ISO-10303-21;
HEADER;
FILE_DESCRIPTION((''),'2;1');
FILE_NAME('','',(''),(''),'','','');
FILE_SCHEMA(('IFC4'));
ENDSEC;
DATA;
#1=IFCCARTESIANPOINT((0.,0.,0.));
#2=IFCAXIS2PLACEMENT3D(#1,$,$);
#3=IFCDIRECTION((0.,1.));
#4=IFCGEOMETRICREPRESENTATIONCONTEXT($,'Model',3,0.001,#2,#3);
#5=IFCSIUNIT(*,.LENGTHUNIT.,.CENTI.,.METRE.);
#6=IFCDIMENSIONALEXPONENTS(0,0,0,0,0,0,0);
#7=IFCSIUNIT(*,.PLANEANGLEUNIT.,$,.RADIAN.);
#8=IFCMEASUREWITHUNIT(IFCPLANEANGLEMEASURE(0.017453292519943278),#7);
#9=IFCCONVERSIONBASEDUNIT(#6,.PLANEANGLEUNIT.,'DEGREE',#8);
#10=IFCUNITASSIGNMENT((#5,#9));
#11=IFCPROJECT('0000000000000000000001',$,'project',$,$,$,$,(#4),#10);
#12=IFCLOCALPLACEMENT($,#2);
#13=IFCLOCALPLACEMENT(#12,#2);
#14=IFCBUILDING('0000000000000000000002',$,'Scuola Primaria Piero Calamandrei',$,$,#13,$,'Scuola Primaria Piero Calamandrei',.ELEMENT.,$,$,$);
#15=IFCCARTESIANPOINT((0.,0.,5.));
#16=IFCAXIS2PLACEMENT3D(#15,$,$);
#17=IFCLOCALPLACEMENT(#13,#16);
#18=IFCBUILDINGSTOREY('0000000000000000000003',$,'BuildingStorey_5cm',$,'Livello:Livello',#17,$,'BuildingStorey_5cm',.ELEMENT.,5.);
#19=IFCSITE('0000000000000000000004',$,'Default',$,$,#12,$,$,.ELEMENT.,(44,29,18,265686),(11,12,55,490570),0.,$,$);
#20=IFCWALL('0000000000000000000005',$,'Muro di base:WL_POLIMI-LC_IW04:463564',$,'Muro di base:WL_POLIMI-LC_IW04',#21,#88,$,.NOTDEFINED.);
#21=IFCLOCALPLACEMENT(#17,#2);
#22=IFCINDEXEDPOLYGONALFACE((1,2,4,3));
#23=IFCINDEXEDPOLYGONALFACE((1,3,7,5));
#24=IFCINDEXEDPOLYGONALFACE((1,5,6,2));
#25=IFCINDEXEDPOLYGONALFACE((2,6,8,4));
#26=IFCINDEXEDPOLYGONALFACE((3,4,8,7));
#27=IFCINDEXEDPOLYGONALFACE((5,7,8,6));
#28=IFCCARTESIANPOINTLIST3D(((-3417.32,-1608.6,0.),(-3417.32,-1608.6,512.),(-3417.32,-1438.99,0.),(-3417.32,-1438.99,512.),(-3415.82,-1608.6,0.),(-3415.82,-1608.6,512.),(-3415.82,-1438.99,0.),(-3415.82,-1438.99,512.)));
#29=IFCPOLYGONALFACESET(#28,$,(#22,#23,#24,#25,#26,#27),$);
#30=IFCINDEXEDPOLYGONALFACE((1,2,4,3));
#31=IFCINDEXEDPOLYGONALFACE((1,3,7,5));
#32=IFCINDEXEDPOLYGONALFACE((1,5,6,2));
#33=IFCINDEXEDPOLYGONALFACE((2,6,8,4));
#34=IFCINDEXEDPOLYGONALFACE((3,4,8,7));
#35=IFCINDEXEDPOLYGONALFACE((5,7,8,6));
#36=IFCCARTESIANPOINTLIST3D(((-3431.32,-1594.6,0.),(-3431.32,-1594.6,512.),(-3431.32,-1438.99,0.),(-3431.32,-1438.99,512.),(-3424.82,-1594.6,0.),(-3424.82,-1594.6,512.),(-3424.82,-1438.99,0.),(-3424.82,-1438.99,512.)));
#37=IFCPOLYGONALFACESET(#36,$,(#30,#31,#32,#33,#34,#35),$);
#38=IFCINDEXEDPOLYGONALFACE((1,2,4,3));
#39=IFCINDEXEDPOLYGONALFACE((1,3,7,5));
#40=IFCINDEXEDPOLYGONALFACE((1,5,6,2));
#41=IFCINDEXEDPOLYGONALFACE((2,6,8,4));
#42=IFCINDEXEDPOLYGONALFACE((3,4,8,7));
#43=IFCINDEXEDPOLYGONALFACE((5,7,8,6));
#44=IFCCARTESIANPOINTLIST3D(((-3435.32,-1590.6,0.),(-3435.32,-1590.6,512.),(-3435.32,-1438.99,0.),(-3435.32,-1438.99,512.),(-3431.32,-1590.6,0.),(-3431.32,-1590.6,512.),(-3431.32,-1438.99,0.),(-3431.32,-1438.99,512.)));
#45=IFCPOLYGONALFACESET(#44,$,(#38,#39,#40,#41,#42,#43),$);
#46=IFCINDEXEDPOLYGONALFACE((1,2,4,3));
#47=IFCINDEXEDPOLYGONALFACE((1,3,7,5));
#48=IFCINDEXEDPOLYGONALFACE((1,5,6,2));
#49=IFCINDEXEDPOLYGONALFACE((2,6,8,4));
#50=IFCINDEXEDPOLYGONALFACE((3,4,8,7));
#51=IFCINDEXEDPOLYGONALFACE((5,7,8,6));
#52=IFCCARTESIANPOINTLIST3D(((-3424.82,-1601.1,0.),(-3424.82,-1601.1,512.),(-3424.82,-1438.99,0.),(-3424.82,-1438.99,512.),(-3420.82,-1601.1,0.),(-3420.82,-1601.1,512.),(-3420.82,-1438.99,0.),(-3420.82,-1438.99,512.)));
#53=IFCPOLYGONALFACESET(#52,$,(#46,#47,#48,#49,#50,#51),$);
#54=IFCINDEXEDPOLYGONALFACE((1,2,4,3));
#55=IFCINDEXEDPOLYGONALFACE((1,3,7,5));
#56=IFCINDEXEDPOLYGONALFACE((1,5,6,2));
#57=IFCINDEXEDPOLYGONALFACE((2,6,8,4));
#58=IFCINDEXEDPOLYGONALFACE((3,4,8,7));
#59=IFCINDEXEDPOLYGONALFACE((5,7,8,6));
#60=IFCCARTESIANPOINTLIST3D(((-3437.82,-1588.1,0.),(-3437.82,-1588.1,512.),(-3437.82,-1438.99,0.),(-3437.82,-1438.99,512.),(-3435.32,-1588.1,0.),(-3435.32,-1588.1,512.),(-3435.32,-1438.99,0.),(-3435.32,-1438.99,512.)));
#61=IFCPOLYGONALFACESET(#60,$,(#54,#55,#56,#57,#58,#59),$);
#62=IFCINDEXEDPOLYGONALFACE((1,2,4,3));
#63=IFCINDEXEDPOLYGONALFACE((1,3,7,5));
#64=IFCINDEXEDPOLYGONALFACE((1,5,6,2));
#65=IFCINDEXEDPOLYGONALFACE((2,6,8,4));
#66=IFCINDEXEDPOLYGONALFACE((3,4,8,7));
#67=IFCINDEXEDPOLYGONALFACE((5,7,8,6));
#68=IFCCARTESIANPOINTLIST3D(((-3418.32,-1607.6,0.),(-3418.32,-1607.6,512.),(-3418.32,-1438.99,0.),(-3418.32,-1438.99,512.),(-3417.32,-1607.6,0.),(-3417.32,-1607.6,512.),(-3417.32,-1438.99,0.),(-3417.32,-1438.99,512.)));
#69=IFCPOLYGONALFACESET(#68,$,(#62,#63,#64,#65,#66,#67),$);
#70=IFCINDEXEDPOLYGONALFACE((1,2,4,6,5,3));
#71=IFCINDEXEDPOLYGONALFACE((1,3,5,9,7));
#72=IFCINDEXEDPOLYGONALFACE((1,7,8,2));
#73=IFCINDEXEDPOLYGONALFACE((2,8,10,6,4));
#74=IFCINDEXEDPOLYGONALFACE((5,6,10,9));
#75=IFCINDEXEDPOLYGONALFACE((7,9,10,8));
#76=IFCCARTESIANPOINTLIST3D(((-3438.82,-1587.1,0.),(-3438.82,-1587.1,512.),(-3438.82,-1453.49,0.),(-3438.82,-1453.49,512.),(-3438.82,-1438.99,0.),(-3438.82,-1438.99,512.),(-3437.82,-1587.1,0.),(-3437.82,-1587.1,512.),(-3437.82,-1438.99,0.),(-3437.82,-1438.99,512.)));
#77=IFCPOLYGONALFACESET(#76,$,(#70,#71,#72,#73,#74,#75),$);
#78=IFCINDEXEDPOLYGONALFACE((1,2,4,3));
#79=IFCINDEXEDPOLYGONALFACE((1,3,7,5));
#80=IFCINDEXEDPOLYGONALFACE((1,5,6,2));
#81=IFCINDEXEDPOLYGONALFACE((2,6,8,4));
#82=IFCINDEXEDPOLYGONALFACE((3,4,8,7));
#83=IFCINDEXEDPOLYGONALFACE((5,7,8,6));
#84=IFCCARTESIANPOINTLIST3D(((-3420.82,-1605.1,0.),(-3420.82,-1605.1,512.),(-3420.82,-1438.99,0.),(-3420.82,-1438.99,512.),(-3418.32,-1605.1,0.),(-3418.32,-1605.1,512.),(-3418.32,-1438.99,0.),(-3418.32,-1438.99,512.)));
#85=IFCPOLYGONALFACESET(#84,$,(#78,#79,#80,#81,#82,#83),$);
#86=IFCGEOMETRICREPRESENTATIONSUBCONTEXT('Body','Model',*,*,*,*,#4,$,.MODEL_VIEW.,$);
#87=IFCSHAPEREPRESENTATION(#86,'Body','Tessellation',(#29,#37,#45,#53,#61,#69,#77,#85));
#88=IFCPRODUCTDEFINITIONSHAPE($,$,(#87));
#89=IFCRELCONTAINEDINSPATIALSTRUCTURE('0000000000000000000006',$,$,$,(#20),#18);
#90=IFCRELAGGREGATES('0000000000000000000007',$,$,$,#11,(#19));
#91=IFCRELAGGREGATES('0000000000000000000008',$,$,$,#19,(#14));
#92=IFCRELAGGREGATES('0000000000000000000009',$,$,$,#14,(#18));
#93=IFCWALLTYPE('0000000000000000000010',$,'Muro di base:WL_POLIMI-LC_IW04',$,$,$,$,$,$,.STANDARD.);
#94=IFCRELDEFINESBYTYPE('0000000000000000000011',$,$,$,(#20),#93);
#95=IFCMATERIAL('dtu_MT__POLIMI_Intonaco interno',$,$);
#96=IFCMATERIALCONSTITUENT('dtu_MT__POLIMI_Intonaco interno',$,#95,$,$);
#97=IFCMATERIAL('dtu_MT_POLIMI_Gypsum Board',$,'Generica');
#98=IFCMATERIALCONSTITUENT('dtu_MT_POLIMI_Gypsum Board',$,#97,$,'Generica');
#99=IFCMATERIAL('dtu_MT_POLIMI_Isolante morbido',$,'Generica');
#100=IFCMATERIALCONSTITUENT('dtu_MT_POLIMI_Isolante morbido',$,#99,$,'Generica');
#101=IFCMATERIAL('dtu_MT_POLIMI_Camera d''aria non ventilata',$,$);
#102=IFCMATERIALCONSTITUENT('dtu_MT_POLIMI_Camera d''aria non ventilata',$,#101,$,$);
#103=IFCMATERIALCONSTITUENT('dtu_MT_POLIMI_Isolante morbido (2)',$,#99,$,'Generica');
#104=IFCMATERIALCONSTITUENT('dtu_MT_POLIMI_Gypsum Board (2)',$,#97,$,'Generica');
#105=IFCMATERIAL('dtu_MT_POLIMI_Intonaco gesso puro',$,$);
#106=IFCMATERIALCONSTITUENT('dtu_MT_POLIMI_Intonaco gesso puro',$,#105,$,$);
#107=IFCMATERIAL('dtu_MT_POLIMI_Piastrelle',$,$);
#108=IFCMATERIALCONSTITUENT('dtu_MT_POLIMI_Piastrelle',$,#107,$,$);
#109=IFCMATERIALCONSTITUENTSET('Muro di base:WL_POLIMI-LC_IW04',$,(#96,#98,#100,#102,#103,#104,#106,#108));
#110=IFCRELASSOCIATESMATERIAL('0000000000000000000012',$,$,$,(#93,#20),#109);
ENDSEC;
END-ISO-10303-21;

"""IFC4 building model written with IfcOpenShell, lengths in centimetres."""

from ifc_helpers import new_model, entity, si_unit, converted_unit, direction, frame, origin, place, context, subcontext, project, spatial, indexed_curve, outline, extrude, material, constituent, constituent_set, type_object, element, save


model = new_model("IFC4")

# Units and contexts
model_context = context("Model", 3, precision=0.001, world=origin(), true_north=direction((0.0, 1.0)))
body_context = subcontext(model_context, "Body", "Model", "MODEL_VIEW")
ifc_project = project(units=[si_unit("LENGTHUNIT", "METRE", prefix="CENTI"), converted_unit("PLANEANGLEUNIT", "DEGREE", entity("IfcPlaneAngleMeasure", 0.017453292519943278), si_unit("PLANEANGLEUNIT", "RADIAN"), dimensions=[0, 0, 0, 0, 0, 0, 0])], contexts=[model_context])

# Site, building, storey
site_placement = place(None, origin())
site = spatial("IfcSite", under=ifc_project, at=site_placement, Name="Default", CompositionType="ELEMENT", RefLatitude=(44, 29, 18, 265686), RefLongitude=(11, 12, 55, 490570), RefElevation=0.0)
building_placement = place(site_placement, origin())
building = spatial("IfcBuilding", under=site, at=building_placement, Name="Scuola Primaria Piero Calamandrei", LongName="Scuola Primaria Piero Calamandrei", CompositionType="ELEMENT")
storey_placement = place(building_placement, frame((0.0, 0.0, 5.0)))
storey = spatial("IfcBuildingStorey", under=building, at=storey_placement, Name="BuildingStorey_5cm", ObjectType="Livello:Livello", LongName="BuildingStorey_5cm", CompositionType="ELEMENT", Elevation=5.0)

# Shared definitions
ifc_material_1 = material(Name="dtu_MT_POLIMI_Intonaco gesso puro")

# Shared definitions
ifc_material_2 = material(Name="dtu_MT__POLIMI_Intonaco interno")

# Shared definitions
ifc_material_3 = material(Name="dtu_MT_POLIMI_Gypsum Board", Category="Generica")
ifc_material_4 = material(Name="dtu_MT_POLIMI_Isolante morbido", Category="Generica")
ifc_material_5 = material(Name="dtu_MT_POLIMI_Camera d'aria non ventilata")

# Shared definitions
ifc_constituent_1 = constituent(ifc_material_2, Name="dtu_MT__POLIMI_Intonaco interno")
ifc_constituent_2 = constituent(ifc_material_3, Name="dtu_MT_POLIMI_Gypsum Board", Category="Generica")
ifc_constituent_3 = constituent(ifc_material_4, Name="dtu_MT_POLIMI_Isolante morbido", Category="Generica")
ifc_constituent_4 = constituent(ifc_material_5, Name="dtu_MT_POLIMI_Camera d'aria non ventilata")
ifc_constituent_5 = constituent(ifc_material_4, Name="dtu_MT_POLIMI_Isolante morbido (2)", Category="Generica")
ifc_constituent_6 = constituent(ifc_material_3, Name="dtu_MT_POLIMI_Gypsum Board (2)", Category="Generica")
ifc_constituent_7 = constituent(ifc_material_1, Name="dtu_MT_POLIMI_Intonaco gesso puro")
ifc_material_6 = material(Name="dtu_MT_POLIMI_Piastrelle")
ifc_constituent_8 = constituent(ifc_material_6, Name="dtu_MT_POLIMI_Piastrelle")
ifc_constituent_set_1 = constituent_set(constituents=[ifc_constituent_1, ifc_constituent_2, ifc_constituent_3, ifc_constituent_4, ifc_constituent_5, ifc_constituent_6, ifc_constituent_7, ifc_constituent_8], Name="Muro di base:WL_POLIMI-LC_IW04")
wall_type_1 = type_object("IfcWallType", Name="Muro di base:WL_POLIMI-LC_IW04", PredefinedType="STANDARD", material=ifc_constituent_set_1)

# Wall
wall_1_placement = place(storey_placement, frame((-3427.32, -1587.1, 0.0), z_axis=(0.0, 0.0, 1.0), x_axis=(0.0, 1.0, 0.0)))
element("IfcWall", 1, at=wall_1_placement, inside=storey, type_object=wall_type_1, material=ifc_constituent_set_1, Name="Muro di base:WL_POLIMI-LC_IW04:463564", ObjectType="Muro di base:WL_POLIMI-LC_IW04", PredefinedType="NOTDEFINED", context=body_context, shape_type="SweptSolid", body=[
    extrude(outline(indexed_curve([(-0.75, -84.8), (0.75, -84.8), (0.75, 84.8), (-0.75, 84.8), (-0.75, -84.8)], self_intersect=False)), frame((63.3, -10.75, 0.0), z_axis=(0.0, 0.0, 1.0), x_axis=(0.0, 1.0, 0.0)), (0.0, 0.0, 1.0), 512.0),
    extrude(outline(indexed_curve([(-77.8, -3.25), (77.8, -3.25), (77.8, 3.25), (-77.8, 3.25), (-77.8, -3.25)], self_intersect=False)), frame((70.3, 0.75, 0.0)), (0.0, 0.0, 1.0), 512.0),
    extrude(outline(indexed_curve([(-75.8, -2.0), (75.8, -2.0), (75.8, 2.0), (-75.8, 2.0), (-75.8, -2.0)], self_intersect=False)), frame((72.3, 6.0, 0.0)), (0.0, 0.0, 1.0), 512.0),
    extrude(outline(indexed_curve([(-81.05, -2.0), (81.05, -2.0), (81.05, 2.0), (-81.05, 2.0), (-81.05, -2.0)], self_intersect=False)), frame((67.05, -4.5, 0.0)), (0.0, 0.0, 1.0), 512.0),
    extrude(outline(indexed_curve([(-74.55, -1.25), (74.55, -1.25), (74.55, 1.25), (-74.55, 1.25), (-74.55, -1.25)], self_intersect=False)), frame((73.55, 9.25, 0.0)), (0.0, 0.0, 1.0), 512.0),
    extrude(outline(indexed_curve([(-84.3, -0.5), (84.3, -0.5), (84.3, 0.5), (-84.3, 0.5), (-84.3, -0.5)], self_intersect=False)), frame((63.8, -9.5, 0.0)), (0.0, 0.0, 1.0), 512.0),
    extrude(outline(indexed_curve([(-47.64, -0.4), (85.97, -0.4), (85.97, 0.6), (-62.14, 0.6), (-62.14, -0.4), (-47.64, -0.4)], self_intersect=False)), frame((85.97, 11.1, 0.0), z_axis=(0.0, 0.0, 1.0), x_axis=(-1.0, 0.0, 0.0)), (0.0, 0.0, 1.0), 512.0),
    extrude(outline(indexed_curve([(-83.05, -1.25), (83.05, -1.25), (83.05, 1.25), (-83.05, 1.25), (-83.05, -1.25)], self_intersect=False)), frame((65.05, -7.75, 0.0)), (0.0, 0.0, 1.0), 512.0),
])

save(model, "model.ifc")
